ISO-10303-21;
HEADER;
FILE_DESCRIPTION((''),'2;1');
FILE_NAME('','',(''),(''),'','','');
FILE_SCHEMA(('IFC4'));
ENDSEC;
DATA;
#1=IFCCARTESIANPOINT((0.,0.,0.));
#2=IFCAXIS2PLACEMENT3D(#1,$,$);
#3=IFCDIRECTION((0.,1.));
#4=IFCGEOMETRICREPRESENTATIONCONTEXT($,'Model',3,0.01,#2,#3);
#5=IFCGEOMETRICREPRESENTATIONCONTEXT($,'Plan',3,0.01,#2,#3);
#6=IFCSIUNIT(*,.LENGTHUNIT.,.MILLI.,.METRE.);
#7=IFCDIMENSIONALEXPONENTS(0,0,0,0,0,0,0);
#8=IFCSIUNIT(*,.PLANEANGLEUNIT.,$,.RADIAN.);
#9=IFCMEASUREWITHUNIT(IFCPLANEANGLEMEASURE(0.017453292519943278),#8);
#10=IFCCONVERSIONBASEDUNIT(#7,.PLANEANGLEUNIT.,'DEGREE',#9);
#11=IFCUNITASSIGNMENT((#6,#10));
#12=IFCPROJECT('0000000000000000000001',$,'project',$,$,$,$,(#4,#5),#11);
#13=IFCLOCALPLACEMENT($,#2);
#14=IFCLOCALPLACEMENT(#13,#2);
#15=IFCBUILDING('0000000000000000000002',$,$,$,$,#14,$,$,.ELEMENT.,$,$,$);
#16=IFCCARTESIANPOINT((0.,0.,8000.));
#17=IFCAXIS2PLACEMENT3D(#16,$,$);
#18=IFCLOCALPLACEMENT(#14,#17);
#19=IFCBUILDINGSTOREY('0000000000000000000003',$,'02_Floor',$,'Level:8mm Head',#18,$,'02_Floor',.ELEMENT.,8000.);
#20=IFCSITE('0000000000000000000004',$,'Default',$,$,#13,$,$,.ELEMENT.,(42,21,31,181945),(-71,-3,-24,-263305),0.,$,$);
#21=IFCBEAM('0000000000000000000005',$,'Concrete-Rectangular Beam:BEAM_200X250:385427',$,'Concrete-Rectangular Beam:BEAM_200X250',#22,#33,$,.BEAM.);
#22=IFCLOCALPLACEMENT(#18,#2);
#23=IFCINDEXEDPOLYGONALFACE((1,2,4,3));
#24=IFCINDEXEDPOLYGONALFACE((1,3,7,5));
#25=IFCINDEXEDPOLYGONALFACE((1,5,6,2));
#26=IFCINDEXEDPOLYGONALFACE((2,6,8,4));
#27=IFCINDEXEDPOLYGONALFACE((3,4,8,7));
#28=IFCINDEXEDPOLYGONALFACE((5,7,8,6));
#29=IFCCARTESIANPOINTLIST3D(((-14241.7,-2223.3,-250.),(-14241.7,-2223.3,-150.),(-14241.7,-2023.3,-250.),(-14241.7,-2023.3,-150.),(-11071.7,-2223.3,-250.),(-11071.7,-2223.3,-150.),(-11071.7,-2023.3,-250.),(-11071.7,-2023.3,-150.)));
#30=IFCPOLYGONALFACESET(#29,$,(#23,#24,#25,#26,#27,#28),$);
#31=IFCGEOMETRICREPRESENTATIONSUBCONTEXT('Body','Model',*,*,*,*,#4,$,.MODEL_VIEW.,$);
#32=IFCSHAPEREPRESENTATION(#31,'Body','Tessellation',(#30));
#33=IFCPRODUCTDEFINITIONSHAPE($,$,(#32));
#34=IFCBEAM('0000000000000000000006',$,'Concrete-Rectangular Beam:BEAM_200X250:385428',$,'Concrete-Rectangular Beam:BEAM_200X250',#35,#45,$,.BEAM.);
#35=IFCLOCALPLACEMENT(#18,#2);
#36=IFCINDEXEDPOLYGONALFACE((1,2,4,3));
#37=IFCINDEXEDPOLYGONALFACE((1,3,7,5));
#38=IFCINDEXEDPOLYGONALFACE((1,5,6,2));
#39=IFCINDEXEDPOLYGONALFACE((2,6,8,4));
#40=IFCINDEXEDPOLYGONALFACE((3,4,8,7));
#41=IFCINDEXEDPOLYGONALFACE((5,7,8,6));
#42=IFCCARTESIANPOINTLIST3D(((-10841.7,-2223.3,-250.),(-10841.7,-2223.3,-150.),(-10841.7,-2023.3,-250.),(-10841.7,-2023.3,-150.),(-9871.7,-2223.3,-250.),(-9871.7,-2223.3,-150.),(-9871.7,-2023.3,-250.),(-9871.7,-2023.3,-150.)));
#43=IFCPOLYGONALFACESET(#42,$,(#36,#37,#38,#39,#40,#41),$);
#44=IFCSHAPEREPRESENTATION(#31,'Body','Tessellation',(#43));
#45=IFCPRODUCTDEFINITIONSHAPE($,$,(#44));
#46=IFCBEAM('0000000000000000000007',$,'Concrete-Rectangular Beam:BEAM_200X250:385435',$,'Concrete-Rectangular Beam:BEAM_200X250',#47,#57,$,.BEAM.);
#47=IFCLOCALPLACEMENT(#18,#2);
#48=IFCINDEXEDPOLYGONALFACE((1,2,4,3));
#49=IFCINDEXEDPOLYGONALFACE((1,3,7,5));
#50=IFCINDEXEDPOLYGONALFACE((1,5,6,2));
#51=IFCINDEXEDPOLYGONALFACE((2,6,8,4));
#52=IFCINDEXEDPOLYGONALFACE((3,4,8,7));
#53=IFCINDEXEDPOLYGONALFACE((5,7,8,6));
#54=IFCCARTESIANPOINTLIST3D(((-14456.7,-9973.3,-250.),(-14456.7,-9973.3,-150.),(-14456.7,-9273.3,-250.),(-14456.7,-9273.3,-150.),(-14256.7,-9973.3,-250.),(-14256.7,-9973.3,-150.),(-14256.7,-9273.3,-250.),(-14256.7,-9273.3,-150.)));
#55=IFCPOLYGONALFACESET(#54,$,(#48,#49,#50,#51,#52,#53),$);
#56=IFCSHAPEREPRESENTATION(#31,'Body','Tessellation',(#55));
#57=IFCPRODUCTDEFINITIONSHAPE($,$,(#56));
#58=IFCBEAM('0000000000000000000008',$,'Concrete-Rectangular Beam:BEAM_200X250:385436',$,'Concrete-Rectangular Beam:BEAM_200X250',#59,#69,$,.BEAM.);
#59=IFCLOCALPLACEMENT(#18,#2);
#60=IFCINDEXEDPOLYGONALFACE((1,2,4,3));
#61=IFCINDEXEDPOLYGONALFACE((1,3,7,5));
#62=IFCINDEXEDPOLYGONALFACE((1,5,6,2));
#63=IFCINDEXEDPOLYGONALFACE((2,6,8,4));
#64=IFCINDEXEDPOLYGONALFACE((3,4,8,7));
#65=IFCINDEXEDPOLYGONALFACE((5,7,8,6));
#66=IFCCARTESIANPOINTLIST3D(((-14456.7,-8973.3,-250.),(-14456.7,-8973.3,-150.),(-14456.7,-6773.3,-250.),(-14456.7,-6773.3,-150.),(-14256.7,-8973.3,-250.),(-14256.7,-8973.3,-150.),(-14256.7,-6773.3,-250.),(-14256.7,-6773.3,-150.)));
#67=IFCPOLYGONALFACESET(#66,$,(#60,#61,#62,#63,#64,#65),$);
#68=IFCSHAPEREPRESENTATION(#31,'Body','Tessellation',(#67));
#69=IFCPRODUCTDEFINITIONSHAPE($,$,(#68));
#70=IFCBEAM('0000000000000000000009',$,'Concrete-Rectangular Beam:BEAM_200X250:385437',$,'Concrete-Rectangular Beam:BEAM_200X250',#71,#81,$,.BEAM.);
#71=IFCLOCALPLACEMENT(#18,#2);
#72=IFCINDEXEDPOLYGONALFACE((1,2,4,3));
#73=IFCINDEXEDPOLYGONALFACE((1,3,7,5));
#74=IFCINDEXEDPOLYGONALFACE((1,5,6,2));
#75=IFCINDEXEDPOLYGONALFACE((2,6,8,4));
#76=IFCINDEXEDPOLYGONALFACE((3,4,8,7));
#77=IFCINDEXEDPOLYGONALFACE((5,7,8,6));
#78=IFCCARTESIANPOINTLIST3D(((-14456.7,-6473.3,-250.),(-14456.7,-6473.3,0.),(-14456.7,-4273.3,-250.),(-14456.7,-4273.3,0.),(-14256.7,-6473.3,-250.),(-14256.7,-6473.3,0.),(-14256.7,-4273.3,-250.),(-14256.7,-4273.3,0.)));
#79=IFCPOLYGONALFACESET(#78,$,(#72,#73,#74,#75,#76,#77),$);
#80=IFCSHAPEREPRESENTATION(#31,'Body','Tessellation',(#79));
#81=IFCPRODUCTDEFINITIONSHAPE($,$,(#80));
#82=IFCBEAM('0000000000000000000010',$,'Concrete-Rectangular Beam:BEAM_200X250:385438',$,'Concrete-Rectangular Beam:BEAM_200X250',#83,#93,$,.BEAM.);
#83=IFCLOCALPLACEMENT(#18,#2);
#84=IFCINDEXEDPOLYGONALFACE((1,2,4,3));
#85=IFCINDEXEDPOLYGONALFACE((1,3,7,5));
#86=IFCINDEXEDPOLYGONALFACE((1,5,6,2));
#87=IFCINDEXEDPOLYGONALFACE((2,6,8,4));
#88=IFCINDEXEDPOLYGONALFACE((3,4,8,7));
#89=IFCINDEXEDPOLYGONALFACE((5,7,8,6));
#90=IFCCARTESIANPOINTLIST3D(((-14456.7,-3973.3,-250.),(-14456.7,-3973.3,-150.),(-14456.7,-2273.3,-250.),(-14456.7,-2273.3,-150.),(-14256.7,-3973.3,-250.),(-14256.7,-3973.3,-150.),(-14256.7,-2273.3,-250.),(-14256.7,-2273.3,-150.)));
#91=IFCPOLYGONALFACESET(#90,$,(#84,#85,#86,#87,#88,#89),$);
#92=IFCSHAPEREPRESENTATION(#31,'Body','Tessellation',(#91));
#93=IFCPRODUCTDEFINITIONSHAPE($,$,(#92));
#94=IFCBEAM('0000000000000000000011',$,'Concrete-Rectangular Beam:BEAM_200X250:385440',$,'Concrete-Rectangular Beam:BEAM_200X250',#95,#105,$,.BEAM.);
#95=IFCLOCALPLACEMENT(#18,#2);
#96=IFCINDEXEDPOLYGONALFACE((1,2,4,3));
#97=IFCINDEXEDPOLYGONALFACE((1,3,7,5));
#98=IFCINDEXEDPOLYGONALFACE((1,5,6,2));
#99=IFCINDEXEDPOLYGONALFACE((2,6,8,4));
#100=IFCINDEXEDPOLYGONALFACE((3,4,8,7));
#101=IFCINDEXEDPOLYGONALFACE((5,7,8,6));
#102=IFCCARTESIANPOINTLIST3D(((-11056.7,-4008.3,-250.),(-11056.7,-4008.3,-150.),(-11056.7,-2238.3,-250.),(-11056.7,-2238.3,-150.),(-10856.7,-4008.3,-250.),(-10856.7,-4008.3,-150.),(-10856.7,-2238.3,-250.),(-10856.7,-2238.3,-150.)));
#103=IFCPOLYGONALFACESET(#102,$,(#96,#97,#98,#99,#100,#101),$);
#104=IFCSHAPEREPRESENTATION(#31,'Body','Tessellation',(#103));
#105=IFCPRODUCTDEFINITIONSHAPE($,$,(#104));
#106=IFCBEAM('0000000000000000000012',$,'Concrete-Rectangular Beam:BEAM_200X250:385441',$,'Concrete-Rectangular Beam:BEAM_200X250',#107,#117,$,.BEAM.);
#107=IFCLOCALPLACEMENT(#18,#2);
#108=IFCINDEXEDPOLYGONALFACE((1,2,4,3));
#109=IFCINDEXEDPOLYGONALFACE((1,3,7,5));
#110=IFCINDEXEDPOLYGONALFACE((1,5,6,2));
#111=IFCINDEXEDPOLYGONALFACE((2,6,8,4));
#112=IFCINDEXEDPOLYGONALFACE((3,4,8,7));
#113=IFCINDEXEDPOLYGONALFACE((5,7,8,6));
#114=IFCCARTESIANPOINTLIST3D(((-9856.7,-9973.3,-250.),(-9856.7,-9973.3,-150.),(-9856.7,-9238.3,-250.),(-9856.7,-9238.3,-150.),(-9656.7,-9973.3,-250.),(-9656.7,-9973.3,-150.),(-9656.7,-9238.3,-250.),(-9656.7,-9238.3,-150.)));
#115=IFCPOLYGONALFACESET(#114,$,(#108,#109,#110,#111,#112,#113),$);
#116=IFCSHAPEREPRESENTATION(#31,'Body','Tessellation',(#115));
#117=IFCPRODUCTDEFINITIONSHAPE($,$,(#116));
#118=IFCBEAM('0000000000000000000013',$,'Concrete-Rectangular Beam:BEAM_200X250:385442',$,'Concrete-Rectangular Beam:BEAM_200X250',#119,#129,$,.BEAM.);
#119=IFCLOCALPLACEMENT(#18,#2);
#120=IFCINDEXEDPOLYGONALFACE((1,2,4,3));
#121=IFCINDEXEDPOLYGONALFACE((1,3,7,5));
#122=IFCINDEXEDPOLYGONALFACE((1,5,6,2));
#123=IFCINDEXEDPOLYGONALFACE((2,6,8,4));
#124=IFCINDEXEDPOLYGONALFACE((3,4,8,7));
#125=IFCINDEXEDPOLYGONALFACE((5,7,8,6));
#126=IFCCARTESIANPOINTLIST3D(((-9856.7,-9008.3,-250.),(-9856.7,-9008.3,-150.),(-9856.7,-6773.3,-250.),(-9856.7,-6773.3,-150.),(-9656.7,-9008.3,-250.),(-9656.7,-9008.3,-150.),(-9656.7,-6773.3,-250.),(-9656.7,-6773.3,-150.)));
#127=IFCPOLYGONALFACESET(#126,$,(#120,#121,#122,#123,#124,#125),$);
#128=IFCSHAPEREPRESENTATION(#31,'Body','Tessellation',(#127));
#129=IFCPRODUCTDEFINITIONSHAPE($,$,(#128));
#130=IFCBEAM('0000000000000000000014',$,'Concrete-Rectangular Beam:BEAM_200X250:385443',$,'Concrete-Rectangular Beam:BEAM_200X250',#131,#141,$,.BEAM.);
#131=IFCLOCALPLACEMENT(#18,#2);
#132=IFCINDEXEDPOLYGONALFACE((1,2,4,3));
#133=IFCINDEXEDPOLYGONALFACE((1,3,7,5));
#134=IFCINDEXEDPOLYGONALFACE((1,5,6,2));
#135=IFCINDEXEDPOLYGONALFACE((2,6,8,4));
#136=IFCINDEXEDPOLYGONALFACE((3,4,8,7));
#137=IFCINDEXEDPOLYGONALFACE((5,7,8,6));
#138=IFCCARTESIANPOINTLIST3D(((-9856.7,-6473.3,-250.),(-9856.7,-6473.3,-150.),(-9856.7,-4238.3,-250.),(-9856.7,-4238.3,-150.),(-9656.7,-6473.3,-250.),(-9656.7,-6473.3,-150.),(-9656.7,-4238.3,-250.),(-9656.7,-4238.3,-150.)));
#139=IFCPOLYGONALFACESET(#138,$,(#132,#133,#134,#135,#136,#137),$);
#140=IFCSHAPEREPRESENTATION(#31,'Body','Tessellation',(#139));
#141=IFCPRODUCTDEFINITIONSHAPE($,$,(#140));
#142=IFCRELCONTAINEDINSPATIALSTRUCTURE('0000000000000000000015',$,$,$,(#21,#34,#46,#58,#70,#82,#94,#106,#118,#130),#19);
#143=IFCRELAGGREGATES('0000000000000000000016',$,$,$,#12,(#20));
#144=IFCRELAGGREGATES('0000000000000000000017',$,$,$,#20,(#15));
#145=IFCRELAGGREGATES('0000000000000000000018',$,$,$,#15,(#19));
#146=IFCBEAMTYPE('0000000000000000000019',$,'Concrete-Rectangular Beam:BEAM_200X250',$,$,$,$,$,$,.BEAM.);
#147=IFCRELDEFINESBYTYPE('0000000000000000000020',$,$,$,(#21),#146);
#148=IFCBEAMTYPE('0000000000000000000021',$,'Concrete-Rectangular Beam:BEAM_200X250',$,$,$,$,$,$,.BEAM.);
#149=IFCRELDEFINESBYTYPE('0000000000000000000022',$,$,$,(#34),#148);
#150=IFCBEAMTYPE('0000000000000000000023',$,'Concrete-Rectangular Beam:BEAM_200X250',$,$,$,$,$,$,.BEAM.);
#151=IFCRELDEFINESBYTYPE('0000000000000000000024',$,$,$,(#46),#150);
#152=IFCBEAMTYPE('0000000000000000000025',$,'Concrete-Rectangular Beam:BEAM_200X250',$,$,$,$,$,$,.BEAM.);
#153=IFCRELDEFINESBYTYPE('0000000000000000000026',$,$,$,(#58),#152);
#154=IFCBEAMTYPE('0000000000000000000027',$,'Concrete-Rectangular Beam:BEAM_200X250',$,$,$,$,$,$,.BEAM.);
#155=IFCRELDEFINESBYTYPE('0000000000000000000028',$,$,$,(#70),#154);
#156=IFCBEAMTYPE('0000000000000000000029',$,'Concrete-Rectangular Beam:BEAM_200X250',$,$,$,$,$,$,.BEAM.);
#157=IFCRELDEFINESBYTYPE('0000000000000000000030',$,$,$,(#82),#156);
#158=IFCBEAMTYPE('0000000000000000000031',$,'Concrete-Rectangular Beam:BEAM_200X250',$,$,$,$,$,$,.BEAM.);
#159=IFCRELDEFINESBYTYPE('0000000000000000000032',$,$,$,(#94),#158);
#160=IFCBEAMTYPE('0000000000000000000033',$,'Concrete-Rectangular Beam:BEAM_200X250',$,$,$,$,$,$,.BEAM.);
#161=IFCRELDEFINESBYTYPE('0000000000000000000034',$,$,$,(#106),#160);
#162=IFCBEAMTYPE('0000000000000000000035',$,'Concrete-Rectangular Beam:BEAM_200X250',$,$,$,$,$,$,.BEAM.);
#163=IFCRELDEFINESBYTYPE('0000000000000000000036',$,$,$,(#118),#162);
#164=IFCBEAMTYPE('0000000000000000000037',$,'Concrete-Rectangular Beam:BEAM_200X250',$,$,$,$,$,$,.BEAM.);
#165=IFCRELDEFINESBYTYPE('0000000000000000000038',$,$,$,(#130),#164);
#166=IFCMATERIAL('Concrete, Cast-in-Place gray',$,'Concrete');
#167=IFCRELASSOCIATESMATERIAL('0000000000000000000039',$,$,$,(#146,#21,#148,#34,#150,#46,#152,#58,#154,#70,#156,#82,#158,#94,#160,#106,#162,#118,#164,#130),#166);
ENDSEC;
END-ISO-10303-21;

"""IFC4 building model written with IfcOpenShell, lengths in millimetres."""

from ifc_helpers import new_model, entity, si_unit, converted_unit, direction, frame, origin, place, context, subcontext, project, spatial, indexed_curve, outline, extrude, source, transform, mapped, material, type_object, type_shapes, element, save


model = new_model("IFC4")

# Units and contexts
model_context = context("Model", 3, precision=0.01, world=origin(), true_north=direction((0.0, 1.0)))
plan_context = context("Plan", 3, precision=0.01, world=origin(), true_north=direction((0.0, 1.0)))
body_context = subcontext(model_context, "Body", "Model", "MODEL_VIEW")
ifc_project = project(units=[si_unit("LENGTHUNIT", "METRE", prefix="MILLI"), converted_unit("PLANEANGLEUNIT", "DEGREE", entity("IfcPlaneAngleMeasure", 0.017453292519943278), si_unit("PLANEANGLEUNIT", "RADIAN"), dimensions=[0, 0, 0, 0, 0, 0, 0])], contexts=[model_context, plan_context])

# Site, building, storey
site_placement = place(None, origin())
site = spatial("IfcSite", under=ifc_project, at=site_placement, Name="Default", CompositionType="ELEMENT", RefLatitude=(42, 21, 31, 181945), RefLongitude=(-71, -3, -24, -263305), RefElevation=0.0)
building_placement = place(site_placement, origin())
building = spatial("IfcBuilding", under=site, at=building_placement, CompositionType="ELEMENT")
storey_placement = place(building_placement, frame((0.0, 0.0, 8000.0)))
storey = spatial("IfcBuildingStorey", under=building, at=storey_placement, Name="02_Floor", ObjectType="Level:8mm Head", LongName="02_Floor", CompositionType="ELEMENT", Elevation=8000.0)

# Beams
ifc_material_1 = material(Name="Concrete, Cast-in-Place gray", Category="Concrete")
beam_type_1 = type_object("IfcBeamType", Name="Concrete-Rectangular Beam:BEAM_200X250", PredefinedType="BEAM", material=ifc_material_1)
shared_shape_1 = source(origin(), body_context, "Body", "SweptSolid", [
    extrude(outline(indexed_curve([(-50.0, -100.0), (50.0, -100.0), (50.0, 100.0), (-50.0, 100.0), (-50.0, -100.0)], self_intersect=False)), frame((-14241.7, -2123.3, 7800.0), z_axis=(1.0, 0.0, 0.0), x_axis=(0.0, 0.0, -1.0)), (0.0, 0.0, 1.0), 3170.0),
])
type_shapes(beam_type_1, [shared_shape_1])
beam_1_placement = place(storey_placement, frame((0.0, 0.0, -8000.0)))
element("IfcBeam", 1, at=beam_1_placement, inside=storey, type_object=beam_type_1, material=ifc_material_1, Name="Concrete-Rectangular Beam:BEAM_200X250:385427", ObjectType="Concrete-Rectangular Beam:BEAM_200X250", PredefinedType="BEAM", context=body_context, shape_type="MappedRepresentation", body=[
    mapped(shared_shape_1, transform((0.0, 0.0, 0.0), scale=1.0)),
])
beam_type_2 = type_object("IfcBeamType", Name="Concrete-Rectangular Beam:BEAM_200X250", PredefinedType="BEAM", material=ifc_material_1)
shared_shape_2 = source(origin(), body_context, "Body", "SweptSolid", [
    extrude(outline(indexed_curve([(-50.0, -100.0), (50.0, -100.0), (50.0, 100.0), (-50.0, 100.0), (-50.0, -100.0)], self_intersect=False)), frame((-10841.7, -2123.3, 7800.0), z_axis=(1.0, 0.0, 0.0), x_axis=(0.0, 0.0, -1.0)), (0.0, 0.0, 1.0), 970.0),
])
type_shapes(beam_type_2, [shared_shape_2])
beam_2_placement = place(storey_placement, frame((0.0, 0.0, -8000.0)))
element("IfcBeam", 2, at=beam_2_placement, inside=storey, type_object=beam_type_2, material=ifc_material_1, Name="Concrete-Rectangular Beam:BEAM_200X250:385428", ObjectType="Concrete-Rectangular Beam:BEAM_200X250", PredefinedType="BEAM", context=body_context, shape_type="MappedRepresentation", body=[
    mapped(shared_shape_2, transform((0.0, 0.0, 0.0), scale=1.0)),
])
beam_type_3 = type_object("IfcBeamType", Name="Concrete-Rectangular Beam:BEAM_200X250", PredefinedType="BEAM", material=ifc_material_1)
shared_shape_3 = source(origin(), body_context, "Body", "SweptSolid", [
    extrude(outline(indexed_curve([(-100.0, -50.0), (100.0, -50.0), (100.0, 50.0), (-100.0, 50.0), (-100.0, -50.0)], self_intersect=False)), frame((-14356.7, -9973.3, 7800.0), z_axis=(0.0, 1.0, 0.0), x_axis=(-1.0, 0.0, 0.0)), (0.0, 0.0, 1.0), 700.0),
])
type_shapes(beam_type_3, [shared_shape_3])
beam_3_placement = place(storey_placement, frame((0.0, 0.0, -8000.0)))
element("IfcBeam", 3, at=beam_3_placement, inside=storey, type_object=beam_type_3, material=ifc_material_1, Name="Concrete-Rectangular Beam:BEAM_200X250:385435", ObjectType="Concrete-Rectangular Beam:BEAM_200X250", PredefinedType="BEAM", context=body_context, shape_type="MappedRepresentation", body=[
    mapped(shared_shape_3, transform((0.0, 0.0, 0.0), scale=1.0)),
])
beam_type_4 = type_object("IfcBeamType", Name="Concrete-Rectangular Beam:BEAM_200X250", PredefinedType="BEAM", material=ifc_material_1)
shared_shape_4 = source(origin(), body_context, "Body", "SweptSolid", [
    extrude(outline(indexed_curve([(-100.0, -50.0), (100.0, -50.0), (100.0, 50.0), (-100.0, 50.0), (-100.0, -50.0)], self_intersect=False)), frame((-14356.7, -8973.3, 7800.0), z_axis=(0.0, 1.0, 0.0), x_axis=(-1.0, 0.0, 0.0)), (0.0, 0.0, 1.0), 2200.0),
])
type_shapes(beam_type_4, [shared_shape_4])
beam_4_placement = place(storey_placement, frame((0.0, 0.0, -8000.0)))
element("IfcBeam", 4, at=beam_4_placement, inside=storey, type_object=beam_type_4, material=ifc_material_1, Name="Concrete-Rectangular Beam:BEAM_200X250:385436", ObjectType="Concrete-Rectangular Beam:BEAM_200X250", PredefinedType="BEAM", context=body_context, shape_type="MappedRepresentation", body=[
    mapped(shared_shape_4, transform((0.0, 0.0, 0.0), scale=1.0)),
])
beam_type_5 = type_object("IfcBeamType", Name="Concrete-Rectangular Beam:BEAM_200X250", PredefinedType="BEAM", material=ifc_material_1)
shared_shape_5 = source(origin(), body_context, "Body", "SweptSolid", [
    extrude(outline(indexed_curve([(-100.0, -125.0), (100.0, -125.0), (100.0, 125.0), (-100.0, 125.0), (-100.0, -125.0)], self_intersect=False)), frame((-14356.7, -6473.3, 7875.0), z_axis=(0.0, 1.0, 0.0), x_axis=(-1.0, 0.0, 0.0)), (0.0, 0.0, 1.0), 2200.0),
])
type_shapes(beam_type_5, [shared_shape_5])
beam_5_placement = place(storey_placement, frame((0.0, 0.0, -8000.0)))
element("IfcBeam", 5, at=beam_5_placement, inside=storey, type_object=beam_type_5, material=ifc_material_1, Name="Concrete-Rectangular Beam:BEAM_200X250:385437", ObjectType="Concrete-Rectangular Beam:BEAM_200X250", PredefinedType="BEAM", context=body_context, shape_type="MappedRepresentation", body=[
    mapped(shared_shape_5, transform((0.0, 0.0, 0.0), scale=1.0)),
])
beam_type_6 = type_object("IfcBeamType", Name="Concrete-Rectangular Beam:BEAM_200X250", PredefinedType="BEAM", material=ifc_material_1)
shared_shape_6 = source(origin(), body_context, "Body", "SweptSolid", [
    extrude(outline(indexed_curve([(-100.0, -50.0), (100.0, -50.0), (100.0, 50.0), (-100.0, 50.0), (-100.0, -50.0)], self_intersect=False)), frame((-14356.7, -3973.3, 7800.0), z_axis=(0.0, 1.0, 0.0), x_axis=(-1.0, 0.0, 0.0)), (0.0, 0.0, 1.0), 1700.0),
])
type_shapes(beam_type_6, [shared_shape_6])
beam_6_placement = place(storey_placement, frame((0.0, 0.0, -8000.0)))
element("IfcBeam", 6, at=beam_6_placement, inside=storey, type_object=beam_type_6, material=ifc_material_1, Name="Concrete-Rectangular Beam:BEAM_200X250:385438", ObjectType="Concrete-Rectangular Beam:BEAM_200X250", PredefinedType="BEAM", context=body_context, shape_type="MappedRepresentation", body=[
    mapped(shared_shape_6, transform((0.0, 0.0, 0.0), scale=1.0)),
])
beam_type_7 = type_object("IfcBeamType", Name="Concrete-Rectangular Beam:BEAM_200X250", PredefinedType="BEAM", material=ifc_material_1)
shared_shape_7 = source(origin(), body_context, "Body", "SweptSolid", [
    extrude(outline(indexed_curve([(-100.0, -50.0), (100.0, -50.0), (100.0, 50.0), (-100.0, 50.0), (-100.0, -50.0)], self_intersect=False)), frame((-10956.7, -4008.3, 7800.0), z_axis=(0.0, 1.0, 0.0), x_axis=(-1.0, 0.0, 0.0)), (0.0, 0.0, 1.0), 1770.0),
])
type_shapes(beam_type_7, [shared_shape_7])
beam_7_placement = place(storey_placement, frame((0.0, 0.0, -8000.0)))
element("IfcBeam", 7, at=beam_7_placement, inside=storey, type_object=beam_type_7, material=ifc_material_1, Name="Concrete-Rectangular Beam:BEAM_200X250:385440", ObjectType="Concrete-Rectangular Beam:BEAM_200X250", PredefinedType="BEAM", context=body_context, shape_type="MappedRepresentation", body=[
    mapped(shared_shape_7, transform((0.0, 0.0, 0.0), scale=1.0)),
])
beam_type_8 = type_object("IfcBeamType", Name="Concrete-Rectangular Beam:BEAM_200X250", PredefinedType="BEAM", material=ifc_material_1)
shared_shape_8 = source(origin(), body_context, "Body", "SweptSolid", [
    extrude(outline(indexed_curve([(-100.0, -50.0), (100.0, -50.0), (100.0, 50.0), (-100.0, 50.0), (-100.0, -50.0)], self_intersect=False)), frame((-9756.7, -9973.3, 7800.0), z_axis=(0.0, 1.0, 0.0), x_axis=(-1.0, 0.0, 0.0)), (0.0, 0.0, 1.0), 735.0),
])
type_shapes(beam_type_8, [shared_shape_8])
beam_8_placement = place(storey_placement, frame((0.0, 0.0, -8000.0)))
element("IfcBeam", 8, at=beam_8_placement, inside=storey, type_object=beam_type_8, material=ifc_material_1, Name="Concrete-Rectangular Beam:BEAM_200X250:385441", ObjectType="Concrete-Rectangular Beam:BEAM_200X250", PredefinedType="BEAM", context=body_context, shape_type="MappedRepresentation", body=[
    mapped(shared_shape_8, transform((0.0, 0.0, 0.0), scale=1.0)),
])
beam_type_9 = type_object("IfcBeamType", Name="Concrete-Rectangular Beam:BEAM_200X250", PredefinedType="BEAM", material=ifc_material_1)
shared_shape_9 = source(origin(), body_context, "Body", "SweptSolid", [
    extrude(outline(indexed_curve([(-100.0, -50.0), (100.0, -50.0), (100.0, 50.0), (-100.0, 50.0), (-100.0, -50.0)], self_intersect=False)), frame((-9756.7, -9008.3, 7800.0), z_axis=(0.0, 1.0, 0.0), x_axis=(-1.0, 0.0, 0.0)), (0.0, 0.0, 1.0), 2235.0),
])
type_shapes(beam_type_9, [shared_shape_9])
beam_9_placement = place(storey_placement, frame((0.0, 0.0, -8000.0)))
element("IfcBeam", 9, at=beam_9_placement, inside=storey, type_object=beam_type_9, material=ifc_material_1, Name="Concrete-Rectangular Beam:BEAM_200X250:385442", ObjectType="Concrete-Rectangular Beam:BEAM_200X250", PredefinedType="BEAM", context=body_context, shape_type="MappedRepresentation", body=[
    mapped(shared_shape_9, transform((0.0, 0.0, 0.0), scale=1.0)),
])
beam_type_10 = type_object("IfcBeamType", Name="Concrete-Rectangular Beam:BEAM_200X250", PredefinedType="BEAM", material=ifc_material_1)
shared_shape_10 = source(origin(), body_context, "Body", "SweptSolid", [
    extrude(outline(indexed_curve([(-100.0, -50.0), (100.0, -50.0), (100.0, 50.0), (-100.0, 50.0), (-100.0, -50.0)], self_intersect=False)), frame((-9756.7, -6473.3, 7800.0), z_axis=(0.0, 1.0, 0.0), x_axis=(-1.0, 0.0, 0.0)), (0.0, 0.0, 1.0), 2235.0),
])
type_shapes(beam_type_10, [shared_shape_10])
beam_10_placement = place(storey_placement, frame((0.0, 0.0, -8000.0)))
element("IfcBeam", 10, at=beam_10_placement, inside=storey, type_object=beam_type_10, material=ifc_material_1, Name="Concrete-Rectangular Beam:BEAM_200X250:385443", ObjectType="Concrete-Rectangular Beam:BEAM_200X250", PredefinedType="BEAM", context=body_context, shape_type="MappedRepresentation", body=[
    mapped(shared_shape_10, transform((0.0, 0.0, 0.0), scale=1.0)),
])

save(model, "model.ifc")
